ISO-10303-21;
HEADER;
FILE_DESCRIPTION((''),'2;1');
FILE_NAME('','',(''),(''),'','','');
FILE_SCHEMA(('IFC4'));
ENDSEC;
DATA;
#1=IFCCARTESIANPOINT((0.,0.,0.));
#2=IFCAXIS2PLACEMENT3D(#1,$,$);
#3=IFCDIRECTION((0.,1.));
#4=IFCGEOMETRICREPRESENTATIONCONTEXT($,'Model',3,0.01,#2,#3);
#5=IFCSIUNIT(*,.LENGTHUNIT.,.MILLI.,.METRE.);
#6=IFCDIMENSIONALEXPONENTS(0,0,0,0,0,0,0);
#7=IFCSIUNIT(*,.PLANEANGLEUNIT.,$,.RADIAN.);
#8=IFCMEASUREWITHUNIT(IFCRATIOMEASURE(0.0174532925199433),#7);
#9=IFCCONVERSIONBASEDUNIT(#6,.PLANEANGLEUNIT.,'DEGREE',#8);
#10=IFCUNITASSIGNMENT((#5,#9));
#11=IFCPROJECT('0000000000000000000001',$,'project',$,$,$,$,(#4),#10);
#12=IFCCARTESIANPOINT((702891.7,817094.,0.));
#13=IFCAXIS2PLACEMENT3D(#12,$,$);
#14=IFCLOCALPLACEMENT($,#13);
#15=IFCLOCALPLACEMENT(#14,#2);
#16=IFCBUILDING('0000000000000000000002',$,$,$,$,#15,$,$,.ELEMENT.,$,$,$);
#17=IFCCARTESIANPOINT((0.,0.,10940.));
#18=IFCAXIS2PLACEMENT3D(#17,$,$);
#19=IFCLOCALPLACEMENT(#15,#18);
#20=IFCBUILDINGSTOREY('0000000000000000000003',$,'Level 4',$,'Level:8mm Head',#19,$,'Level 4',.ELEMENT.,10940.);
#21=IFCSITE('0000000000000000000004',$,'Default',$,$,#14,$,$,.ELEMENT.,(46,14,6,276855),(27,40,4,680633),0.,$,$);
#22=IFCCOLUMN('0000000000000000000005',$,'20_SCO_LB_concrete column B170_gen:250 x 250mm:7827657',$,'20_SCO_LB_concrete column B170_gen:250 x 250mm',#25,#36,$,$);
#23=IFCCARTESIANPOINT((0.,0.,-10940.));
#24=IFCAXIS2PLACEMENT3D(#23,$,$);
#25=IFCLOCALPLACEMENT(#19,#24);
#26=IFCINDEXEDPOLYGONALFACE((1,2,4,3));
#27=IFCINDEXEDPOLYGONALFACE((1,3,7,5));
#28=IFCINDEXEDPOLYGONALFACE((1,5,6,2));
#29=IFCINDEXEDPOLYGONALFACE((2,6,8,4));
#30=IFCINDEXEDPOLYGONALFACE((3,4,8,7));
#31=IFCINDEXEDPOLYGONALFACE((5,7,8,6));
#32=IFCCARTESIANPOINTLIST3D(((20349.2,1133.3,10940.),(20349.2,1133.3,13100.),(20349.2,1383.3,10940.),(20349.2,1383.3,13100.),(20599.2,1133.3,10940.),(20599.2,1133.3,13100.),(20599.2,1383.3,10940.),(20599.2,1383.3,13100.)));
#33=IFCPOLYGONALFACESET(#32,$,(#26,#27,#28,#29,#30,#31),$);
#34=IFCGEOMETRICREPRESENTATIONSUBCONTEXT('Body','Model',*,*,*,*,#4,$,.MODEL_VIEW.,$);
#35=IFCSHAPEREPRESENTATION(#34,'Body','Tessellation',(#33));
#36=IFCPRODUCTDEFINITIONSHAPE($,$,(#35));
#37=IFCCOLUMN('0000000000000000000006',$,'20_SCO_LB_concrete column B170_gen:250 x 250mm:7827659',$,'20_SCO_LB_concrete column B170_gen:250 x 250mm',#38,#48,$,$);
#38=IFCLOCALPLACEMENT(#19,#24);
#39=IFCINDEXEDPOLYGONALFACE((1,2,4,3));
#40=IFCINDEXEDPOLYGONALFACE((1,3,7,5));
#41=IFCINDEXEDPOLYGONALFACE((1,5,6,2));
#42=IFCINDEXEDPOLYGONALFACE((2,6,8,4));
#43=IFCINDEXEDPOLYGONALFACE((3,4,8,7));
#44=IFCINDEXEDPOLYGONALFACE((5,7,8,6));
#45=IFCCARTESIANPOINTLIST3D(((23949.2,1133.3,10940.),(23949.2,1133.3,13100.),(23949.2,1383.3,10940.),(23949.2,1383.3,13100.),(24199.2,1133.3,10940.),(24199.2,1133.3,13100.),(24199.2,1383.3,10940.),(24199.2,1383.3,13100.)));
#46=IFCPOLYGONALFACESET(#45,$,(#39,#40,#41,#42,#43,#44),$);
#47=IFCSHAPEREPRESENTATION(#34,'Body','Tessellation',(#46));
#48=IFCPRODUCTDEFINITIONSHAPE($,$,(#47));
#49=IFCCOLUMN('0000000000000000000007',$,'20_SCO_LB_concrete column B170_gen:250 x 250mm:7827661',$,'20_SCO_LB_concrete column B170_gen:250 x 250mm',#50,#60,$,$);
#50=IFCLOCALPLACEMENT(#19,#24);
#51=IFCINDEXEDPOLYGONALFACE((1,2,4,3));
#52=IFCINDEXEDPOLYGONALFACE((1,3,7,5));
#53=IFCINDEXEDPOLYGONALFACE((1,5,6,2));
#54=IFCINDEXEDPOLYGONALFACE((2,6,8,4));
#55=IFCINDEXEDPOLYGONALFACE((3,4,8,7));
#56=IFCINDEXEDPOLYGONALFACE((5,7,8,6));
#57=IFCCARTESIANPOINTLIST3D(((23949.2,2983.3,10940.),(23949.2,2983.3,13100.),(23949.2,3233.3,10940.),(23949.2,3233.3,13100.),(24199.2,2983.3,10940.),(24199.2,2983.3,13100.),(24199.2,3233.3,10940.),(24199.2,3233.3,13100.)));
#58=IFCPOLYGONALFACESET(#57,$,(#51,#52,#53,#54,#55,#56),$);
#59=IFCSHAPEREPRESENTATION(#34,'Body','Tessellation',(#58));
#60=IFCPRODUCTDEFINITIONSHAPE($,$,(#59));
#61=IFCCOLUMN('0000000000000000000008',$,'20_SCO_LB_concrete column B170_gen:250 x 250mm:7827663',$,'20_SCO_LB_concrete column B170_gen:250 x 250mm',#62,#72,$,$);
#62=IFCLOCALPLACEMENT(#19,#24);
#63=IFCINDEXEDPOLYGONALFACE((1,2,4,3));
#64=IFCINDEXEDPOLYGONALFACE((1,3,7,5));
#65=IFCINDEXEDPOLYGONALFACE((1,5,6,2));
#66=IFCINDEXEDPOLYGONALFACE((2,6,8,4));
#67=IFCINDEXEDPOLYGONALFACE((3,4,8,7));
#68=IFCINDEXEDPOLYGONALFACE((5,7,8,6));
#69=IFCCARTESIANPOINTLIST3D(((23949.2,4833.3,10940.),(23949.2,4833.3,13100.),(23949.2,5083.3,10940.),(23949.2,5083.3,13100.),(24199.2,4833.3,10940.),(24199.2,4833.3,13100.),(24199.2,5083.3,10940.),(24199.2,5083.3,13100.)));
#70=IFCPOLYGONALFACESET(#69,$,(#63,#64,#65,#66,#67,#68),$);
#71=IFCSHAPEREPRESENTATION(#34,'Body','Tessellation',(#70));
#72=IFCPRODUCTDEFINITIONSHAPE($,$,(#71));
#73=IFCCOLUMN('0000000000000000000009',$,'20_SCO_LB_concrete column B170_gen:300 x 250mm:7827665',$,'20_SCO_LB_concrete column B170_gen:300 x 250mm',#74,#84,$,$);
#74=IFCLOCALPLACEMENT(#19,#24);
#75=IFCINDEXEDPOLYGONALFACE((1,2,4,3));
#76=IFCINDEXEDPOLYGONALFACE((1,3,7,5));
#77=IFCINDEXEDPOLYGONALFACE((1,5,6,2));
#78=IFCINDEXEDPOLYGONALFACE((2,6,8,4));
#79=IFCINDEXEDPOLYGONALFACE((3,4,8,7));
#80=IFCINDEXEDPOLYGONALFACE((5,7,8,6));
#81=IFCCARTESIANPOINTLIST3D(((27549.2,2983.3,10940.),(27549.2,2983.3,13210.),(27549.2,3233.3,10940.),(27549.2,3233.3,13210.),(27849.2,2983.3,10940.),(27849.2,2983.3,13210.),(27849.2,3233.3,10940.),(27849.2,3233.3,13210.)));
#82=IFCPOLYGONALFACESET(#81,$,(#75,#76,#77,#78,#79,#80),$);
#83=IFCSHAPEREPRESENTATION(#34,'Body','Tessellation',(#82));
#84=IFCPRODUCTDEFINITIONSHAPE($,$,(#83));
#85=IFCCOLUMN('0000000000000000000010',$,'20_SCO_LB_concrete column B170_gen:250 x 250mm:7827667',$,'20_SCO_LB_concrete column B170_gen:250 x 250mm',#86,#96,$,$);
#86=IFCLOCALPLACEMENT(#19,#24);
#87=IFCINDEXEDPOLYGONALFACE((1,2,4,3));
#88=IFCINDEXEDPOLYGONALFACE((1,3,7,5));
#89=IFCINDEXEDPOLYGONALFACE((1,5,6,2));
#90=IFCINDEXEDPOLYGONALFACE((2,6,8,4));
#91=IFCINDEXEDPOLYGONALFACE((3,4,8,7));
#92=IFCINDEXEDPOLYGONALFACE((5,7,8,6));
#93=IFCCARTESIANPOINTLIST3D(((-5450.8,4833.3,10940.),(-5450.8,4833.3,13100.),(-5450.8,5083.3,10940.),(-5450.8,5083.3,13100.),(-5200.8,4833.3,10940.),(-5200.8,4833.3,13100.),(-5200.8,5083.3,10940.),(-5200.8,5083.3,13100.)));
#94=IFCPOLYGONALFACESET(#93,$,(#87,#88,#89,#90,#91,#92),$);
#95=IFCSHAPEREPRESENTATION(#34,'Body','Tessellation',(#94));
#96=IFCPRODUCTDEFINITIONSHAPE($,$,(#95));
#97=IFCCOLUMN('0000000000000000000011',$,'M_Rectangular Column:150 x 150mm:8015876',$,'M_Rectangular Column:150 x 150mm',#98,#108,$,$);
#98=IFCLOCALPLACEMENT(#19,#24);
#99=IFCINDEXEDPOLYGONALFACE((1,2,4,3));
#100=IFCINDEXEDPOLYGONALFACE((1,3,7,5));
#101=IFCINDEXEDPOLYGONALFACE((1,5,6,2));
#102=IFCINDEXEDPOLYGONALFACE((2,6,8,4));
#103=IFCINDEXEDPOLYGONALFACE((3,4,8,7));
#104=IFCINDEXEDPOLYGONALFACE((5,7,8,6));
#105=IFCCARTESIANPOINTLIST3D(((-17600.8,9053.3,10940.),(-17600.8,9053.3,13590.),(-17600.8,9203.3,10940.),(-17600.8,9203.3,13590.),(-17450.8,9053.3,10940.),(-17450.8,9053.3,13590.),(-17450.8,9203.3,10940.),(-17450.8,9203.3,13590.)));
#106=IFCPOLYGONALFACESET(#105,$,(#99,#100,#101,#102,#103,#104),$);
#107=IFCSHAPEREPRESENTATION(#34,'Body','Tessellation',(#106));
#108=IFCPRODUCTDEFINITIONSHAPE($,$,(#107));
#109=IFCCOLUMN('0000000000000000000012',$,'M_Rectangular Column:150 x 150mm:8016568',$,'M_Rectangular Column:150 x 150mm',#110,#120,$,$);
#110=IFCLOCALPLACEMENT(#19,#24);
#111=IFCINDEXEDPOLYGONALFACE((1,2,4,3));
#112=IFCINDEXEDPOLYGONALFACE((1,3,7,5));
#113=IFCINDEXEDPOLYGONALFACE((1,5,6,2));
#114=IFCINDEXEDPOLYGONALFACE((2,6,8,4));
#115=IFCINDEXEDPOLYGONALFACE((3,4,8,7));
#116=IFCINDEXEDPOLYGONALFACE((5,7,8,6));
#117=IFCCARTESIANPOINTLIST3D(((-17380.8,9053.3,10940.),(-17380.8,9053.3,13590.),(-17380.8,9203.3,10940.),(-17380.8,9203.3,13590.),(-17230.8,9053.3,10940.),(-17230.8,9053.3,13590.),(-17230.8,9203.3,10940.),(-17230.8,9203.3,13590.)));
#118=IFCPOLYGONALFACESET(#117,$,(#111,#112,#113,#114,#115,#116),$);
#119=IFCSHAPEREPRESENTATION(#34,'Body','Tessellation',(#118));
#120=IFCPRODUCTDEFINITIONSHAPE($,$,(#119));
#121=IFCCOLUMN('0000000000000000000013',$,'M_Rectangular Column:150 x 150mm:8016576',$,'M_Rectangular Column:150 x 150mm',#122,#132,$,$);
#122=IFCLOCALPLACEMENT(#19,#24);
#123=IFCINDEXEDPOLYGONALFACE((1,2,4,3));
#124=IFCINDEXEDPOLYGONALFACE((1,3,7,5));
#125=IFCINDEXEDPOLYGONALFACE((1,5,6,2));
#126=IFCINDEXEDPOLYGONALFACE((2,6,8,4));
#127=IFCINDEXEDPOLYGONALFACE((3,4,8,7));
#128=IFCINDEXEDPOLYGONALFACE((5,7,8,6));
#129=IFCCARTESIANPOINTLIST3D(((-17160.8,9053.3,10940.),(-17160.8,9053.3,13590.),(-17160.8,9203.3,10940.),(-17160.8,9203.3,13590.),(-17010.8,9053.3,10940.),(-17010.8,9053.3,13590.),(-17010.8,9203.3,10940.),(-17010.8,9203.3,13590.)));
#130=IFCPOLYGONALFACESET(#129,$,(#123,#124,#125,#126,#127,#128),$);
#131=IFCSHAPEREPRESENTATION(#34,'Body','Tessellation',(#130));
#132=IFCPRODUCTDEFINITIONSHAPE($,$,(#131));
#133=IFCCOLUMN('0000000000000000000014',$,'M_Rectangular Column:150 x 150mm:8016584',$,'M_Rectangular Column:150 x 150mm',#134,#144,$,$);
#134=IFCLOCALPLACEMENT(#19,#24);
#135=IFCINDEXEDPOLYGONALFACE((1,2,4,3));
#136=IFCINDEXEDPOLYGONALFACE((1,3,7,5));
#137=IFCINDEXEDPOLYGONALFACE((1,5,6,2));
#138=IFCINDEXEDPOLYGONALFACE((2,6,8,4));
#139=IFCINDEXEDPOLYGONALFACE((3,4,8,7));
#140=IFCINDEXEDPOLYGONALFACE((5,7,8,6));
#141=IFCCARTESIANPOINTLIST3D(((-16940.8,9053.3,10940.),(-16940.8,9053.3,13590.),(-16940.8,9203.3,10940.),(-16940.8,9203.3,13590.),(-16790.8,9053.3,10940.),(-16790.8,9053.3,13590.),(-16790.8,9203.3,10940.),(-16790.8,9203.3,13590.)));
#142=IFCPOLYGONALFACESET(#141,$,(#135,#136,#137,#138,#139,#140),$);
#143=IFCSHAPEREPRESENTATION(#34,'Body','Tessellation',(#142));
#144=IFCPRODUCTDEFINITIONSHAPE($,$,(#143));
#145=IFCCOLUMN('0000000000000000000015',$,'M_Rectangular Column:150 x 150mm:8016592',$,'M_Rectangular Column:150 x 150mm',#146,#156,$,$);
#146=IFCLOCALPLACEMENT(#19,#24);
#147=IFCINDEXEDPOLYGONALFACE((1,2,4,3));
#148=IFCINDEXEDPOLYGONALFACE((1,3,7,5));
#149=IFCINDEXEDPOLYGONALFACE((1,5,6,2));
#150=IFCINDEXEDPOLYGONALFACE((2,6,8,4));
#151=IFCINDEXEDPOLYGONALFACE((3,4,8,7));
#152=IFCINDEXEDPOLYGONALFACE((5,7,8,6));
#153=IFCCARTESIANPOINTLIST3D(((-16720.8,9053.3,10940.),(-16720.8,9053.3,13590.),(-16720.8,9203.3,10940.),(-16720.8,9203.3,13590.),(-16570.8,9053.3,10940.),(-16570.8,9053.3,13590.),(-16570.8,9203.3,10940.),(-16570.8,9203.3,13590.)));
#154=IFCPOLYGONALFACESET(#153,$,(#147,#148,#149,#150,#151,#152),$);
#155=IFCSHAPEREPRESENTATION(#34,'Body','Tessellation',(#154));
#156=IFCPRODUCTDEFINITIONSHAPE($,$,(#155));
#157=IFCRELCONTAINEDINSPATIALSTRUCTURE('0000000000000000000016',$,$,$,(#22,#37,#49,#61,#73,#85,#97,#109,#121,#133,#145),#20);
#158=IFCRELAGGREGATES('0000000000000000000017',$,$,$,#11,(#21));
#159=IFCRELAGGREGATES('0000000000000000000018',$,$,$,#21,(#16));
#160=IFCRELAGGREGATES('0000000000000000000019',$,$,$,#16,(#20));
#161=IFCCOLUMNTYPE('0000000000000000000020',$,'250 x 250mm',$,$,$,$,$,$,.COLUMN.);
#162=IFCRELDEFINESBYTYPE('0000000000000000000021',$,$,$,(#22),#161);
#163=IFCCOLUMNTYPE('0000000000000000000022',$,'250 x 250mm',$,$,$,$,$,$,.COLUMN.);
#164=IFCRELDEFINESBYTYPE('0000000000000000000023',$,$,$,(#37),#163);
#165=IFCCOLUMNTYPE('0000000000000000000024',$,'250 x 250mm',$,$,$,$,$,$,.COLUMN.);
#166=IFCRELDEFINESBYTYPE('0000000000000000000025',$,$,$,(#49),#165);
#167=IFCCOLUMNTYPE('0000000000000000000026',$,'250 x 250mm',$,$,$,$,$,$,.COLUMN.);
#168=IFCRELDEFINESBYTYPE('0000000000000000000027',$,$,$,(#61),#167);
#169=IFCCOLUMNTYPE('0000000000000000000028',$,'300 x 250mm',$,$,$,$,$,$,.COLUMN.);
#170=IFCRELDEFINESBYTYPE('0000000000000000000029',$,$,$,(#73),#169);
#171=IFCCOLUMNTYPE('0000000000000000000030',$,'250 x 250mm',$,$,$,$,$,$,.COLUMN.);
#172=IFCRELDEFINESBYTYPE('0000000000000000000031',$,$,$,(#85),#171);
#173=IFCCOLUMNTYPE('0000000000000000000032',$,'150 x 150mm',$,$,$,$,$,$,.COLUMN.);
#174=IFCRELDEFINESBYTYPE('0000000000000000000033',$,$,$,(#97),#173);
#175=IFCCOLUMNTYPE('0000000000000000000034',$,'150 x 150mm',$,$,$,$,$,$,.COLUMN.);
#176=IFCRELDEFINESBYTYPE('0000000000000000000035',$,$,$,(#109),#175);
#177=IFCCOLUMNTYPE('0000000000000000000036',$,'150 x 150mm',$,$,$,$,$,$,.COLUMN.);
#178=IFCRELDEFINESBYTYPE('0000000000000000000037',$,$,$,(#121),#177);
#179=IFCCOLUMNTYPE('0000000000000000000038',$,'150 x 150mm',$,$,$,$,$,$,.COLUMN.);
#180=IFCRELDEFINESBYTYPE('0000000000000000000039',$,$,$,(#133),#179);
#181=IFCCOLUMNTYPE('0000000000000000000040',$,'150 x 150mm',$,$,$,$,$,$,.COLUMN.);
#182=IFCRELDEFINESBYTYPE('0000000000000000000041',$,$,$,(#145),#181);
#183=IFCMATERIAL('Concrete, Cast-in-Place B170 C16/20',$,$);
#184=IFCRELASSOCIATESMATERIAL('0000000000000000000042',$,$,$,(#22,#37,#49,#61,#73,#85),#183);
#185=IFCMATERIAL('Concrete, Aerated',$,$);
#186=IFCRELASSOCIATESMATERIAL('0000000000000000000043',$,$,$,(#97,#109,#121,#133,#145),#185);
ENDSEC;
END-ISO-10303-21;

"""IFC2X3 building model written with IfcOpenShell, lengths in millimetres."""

from ifc_helpers import new_model, entity, si_unit, converted_unit, direction, frame, frame_2d, origin, place, context, subcontext, project, spatial, rectangle, extrude, source, transform, mapped, material, type_object, type_shapes, element, save


model = new_model("IFC2X3")

# Units and contexts
model_context = context("Model", 3, precision=0.01, world=origin(), true_north=direction((0.0, 1.0)))
body_context = subcontext(model_context, "Body", "Model", "MODEL_VIEW")
ifc_project = project(units=[si_unit("LENGTHUNIT", "METRE", prefix="MILLI"), converted_unit("PLANEANGLEUNIT", "DEGREE", entity("IfcRatioMeasure", 0.0174532925199433), si_unit("PLANEANGLEUNIT", "RADIAN"), dimensions=[0, 0, 0, 0, 0, 0, 0])], contexts=[model_context])

# Site, building, storey
site_placement = place(None, frame((702891.7, 817094.0, 0.0)))
site = spatial("IfcSite", under=ifc_project, at=site_placement, Name="Default", CompositionType="ELEMENT", RefLatitude=(46, 14, 6, 276855), RefLongitude=(27, 40, 4, 680633), RefElevation=0.0)
building_placement = place(site_placement, origin())
building = spatial("IfcBuilding", under=site, at=building_placement, CompositionType="ELEMENT")
storey_placement = place(building_placement, frame((0.0, 0.0, 10940.0)))
storey = spatial("IfcBuildingStorey", under=building, at=storey_placement, Name="Level 4", ObjectType="Level:8mm Head", LongName="Level 4", CompositionType="ELEMENT", Elevation=10940.0)

# Columns
ifc_material_1 = material(Name="Concrete, Cast-in-Place B170 C16/20")
column_type_1 = type_object("IfcColumnType", Name="250 x 250mm", PredefinedType="COLUMN")
shared_shape_1 = source(origin(), body_context, "Body", "SweptSolid", [
    extrude(rectangle(XDim=250.0, YDim=250.0, at=frame_2d((0.0, 0.0), x_axis=(1.0, 0.0))), frame((20474.2, 1258.3, 10940.0), z_axis=(0.0, 0.0, 1.0), x_axis=(0.0, -1.0, 0.0)), (0.0, 0.0, 1.0), 2160.0),
])
type_shapes(column_type_1, [shared_shape_1])
column_1_placement = place(storey_placement, frame((0.0, 0.0, -10940.0)))
element("IfcColumn", 1, at=column_1_placement, inside=storey, type_object=column_type_1, material=ifc_material_1, Name="20_SCO_LB_concrete column B170_gen:250 x 250mm:7827657", ObjectType="20_SCO_LB_concrete column B170_gen:250 x 250mm", context=body_context, shape_type="MappedRepresentation", body=[
    mapped(shared_shape_1, transform((0.0, 0.0, 0.0), scale=1.0)),
])
column_type_2 = type_object("IfcColumnType", Name="250 x 250mm", PredefinedType="COLUMN")
shared_shape_2 = source(origin(), body_context, "Body", "SweptSolid", [
    extrude(rectangle(XDim=250.0, YDim=250.0, at=frame_2d((0.0, 0.0), x_axis=(1.0, 0.0))), frame((24074.2, 1258.3, 10940.0), z_axis=(0.0, 0.0, 1.0), x_axis=(0.0, -1.0, 0.0)), (0.0, 0.0, 1.0), 2160.0),
])
type_shapes(column_type_2, [shared_shape_2])
column_2_placement = place(storey_placement, frame((0.0, 0.0, -10940.0)))
element("IfcColumn", 2, at=column_2_placement, inside=storey, type_object=column_type_2, material=ifc_material_1, Name="20_SCO_LB_concrete column B170_gen:250 x 250mm:7827659", ObjectType="20_SCO_LB_concrete column B170_gen:250 x 250mm", context=body_context, shape_type="MappedRepresentation", body=[
    mapped(shared_shape_2, transform((0.0, 0.0, 0.0), scale=1.0)),
])
column_type_3 = type_object("IfcColumnType", Name="250 x 250mm", PredefinedType="COLUMN")
shared_shape_3 = source(origin(), body_context, "Body", "SweptSolid", [
    extrude(rectangle(XDim=250.0, YDim=250.0, at=frame_2d((0.0, 0.0), x_axis=(1.0, 0.0))), frame((24074.2, 3108.3, 10940.0), z_axis=(0.0, 0.0, 1.0), x_axis=(0.0, -1.0, 0.0)), (0.0, 0.0, 1.0), 2160.0),
])
type_shapes(column_type_3, [shared_shape_3])
column_3_placement = place(storey_placement, frame((0.0, 0.0, -10940.0)))
element("IfcColumn", 3, at=column_3_placement, inside=storey, type_object=column_type_3, material=ifc_material_1, Name="20_SCO_LB_concrete column B170_gen:250 x 250mm:7827661", ObjectType="20_SCO_LB_concrete column B170_gen:250 x 250mm", context=body_context, shape_type="MappedRepresentation", body=[
    mapped(shared_shape_3, transform((0.0, 0.0, 0.0), scale=1.0)),
])
column_type_4 = type_object("IfcColumnType", Name="250 x 250mm", PredefinedType="COLUMN")
shared_shape_4 = source(origin(), body_context, "Body", "SweptSolid", [
    extrude(rectangle(XDim=250.0, YDim=250.0, at=frame_2d((0.0, 0.0), x_axis=(1.0, 0.0))), frame((24074.2, 4958.3, 10940.0), z_axis=(0.0, 0.0, 1.0), x_axis=(0.0, -1.0, 0.0)), (0.0, 0.0, 1.0), 2160.0),
])
type_shapes(column_type_4, [shared_shape_4])
column_4_placement = place(storey_placement, frame((0.0, 0.0, -10940.0)))
element("IfcColumn", 4, at=column_4_placement, inside=storey, type_object=column_type_4, material=ifc_material_1, Name="20_SCO_LB_concrete column B170_gen:250 x 250mm:7827663", ObjectType="20_SCO_LB_concrete column B170_gen:250 x 250mm", context=body_context, shape_type="MappedRepresentation", body=[
    mapped(shared_shape_4, transform((0.0, 0.0, 0.0), scale=1.0)),
])
column_type_5 = type_object("IfcColumnType", Name="300 x 250mm", PredefinedType="COLUMN")
shared_shape_5 = source(origin(), body_context, "Body", "SweptSolid", [
    extrude(rectangle(XDim=250.0, YDim=300.0, at=frame_2d((0.0, 0.0), x_axis=(1.0, 0.0))), frame((27699.2, 3108.3, 10940.0), z_axis=(0.0, 0.0, 1.0), x_axis=(0.0, -1.0, 0.0)), (0.0, 0.0, 1.0), 2270.0),
])
type_shapes(column_type_5, [shared_shape_5])
column_5_placement = place(storey_placement, frame((0.0, 0.0, -10940.0)))
element("IfcColumn", 5, at=column_5_placement, inside=storey, type_object=column_type_5, material=ifc_material_1, Name="20_SCO_LB_concrete column B170_gen:300 x 250mm:7827665", ObjectType="20_SCO_LB_concrete column B170_gen:300 x 250mm", context=body_context, shape_type="MappedRepresentation", body=[
    mapped(shared_shape_5, transform((0.0, 0.0, 0.0), scale=1.0)),
])
column_type_6 = type_object("IfcColumnType", Name="250 x 250mm", PredefinedType="COLUMN")
shared_shape_6 = source(origin(), body_context, "Body", "SweptSolid", [
    extrude(rectangle(XDim=250.0, YDim=250.0, at=frame_2d((0.0, 0.0), x_axis=(1.0, 0.0))), frame((-5325.8, 4958.3, 10940.0), z_axis=(0.0, 0.0, 1.0), x_axis=(0.0, -1.0, 0.0)), (0.0, 0.0, 1.0), 2160.0),
])
type_shapes(column_type_6, [shared_shape_6])
column_6_placement = place(storey_placement, frame((0.0, 0.0, -10940.0)))
element("IfcColumn", 6, at=column_6_placement, inside=storey, type_object=column_type_6, material=ifc_material_1, Name="20_SCO_LB_concrete column B170_gen:250 x 250mm:7827667", ObjectType="20_SCO_LB_concrete column B170_gen:250 x 250mm", context=body_context, shape_type="MappedRepresentation", body=[
    mapped(shared_shape_6, transform((0.0, 0.0, 0.0), scale=1.0)),
])
ifc_material_2 = material(Name="Concrete, Aerated")
column_type_7 = type_object("IfcColumnType", Name="150 x 150mm", PredefinedType="COLUMN")
shared_shape_7 = source(origin(), body_context, "Body", "SweptSolid", [
    extrude(rectangle(XDim=150.0, YDim=150.0, at=frame_2d((0.0, 0.0), x_axis=(1.0, 0.0))), frame((-17525.8, 9128.3, 10940.0), z_axis=(0.0, 0.0, 1.0), x_axis=(0.0, -1.0, 0.0)), (0.0, 0.0, 1.0), 2650.0),
])
type_shapes(column_type_7, [shared_shape_7])
column_7_placement = place(storey_placement, frame((0.0, 0.0, -10940.0)))
element("IfcColumn", 7, at=column_7_placement, inside=storey, type_object=column_type_7, material=ifc_material_2, Name="M_Rectangular Column:150 x 150mm:8015876", ObjectType="M_Rectangular Column:150 x 150mm", context=body_context, shape_type="MappedRepresentation", body=[
    mapped(shared_shape_7, transform((0.0, 0.0, 0.0), scale=1.0)),
])
column_type_8 = type_object("IfcColumnType", Name="150 x 150mm", PredefinedType="COLUMN")
shared_shape_8 = source(origin(), body_context, "Body", "SweptSolid", [
    extrude(rectangle(XDim=150.0, YDim=150.0, at=frame_2d((0.0, 0.0), x_axis=(1.0, 0.0))), frame((-17305.8, 9128.3, 10940.0), z_axis=(0.0, 0.0, 1.0), x_axis=(0.0, -1.0, 0.0)), (0.0, 0.0, 1.0), 2650.0),
])
type_shapes(column_type_8, [shared_shape_8])
column_8_placement = place(storey_placement, frame((0.0, 0.0, -10940.0)))
element("IfcColumn", 8, at=column_8_placement, inside=storey, type_object=column_type_8, material=ifc_material_2, Name="M_Rectangular Column:150 x 150mm:8016568", ObjectType="M_Rectangular Column:150 x 150mm", context=body_context, shape_type="MappedRepresentation", body=[
    mapped(shared_shape_8, transform((0.0, 0.0, 0.0), scale=1.0)),
])
column_type_9 = type_object("IfcColumnType", Name="150 x 150mm", PredefinedType="COLUMN")
shared_shape_9 = source(origin(), body_context, "Body", "SweptSolid", [
    extrude(rectangle(XDim=150.0, YDim=150.0, at=frame_2d((0.0, 0.0), x_axis=(1.0, 0.0))), frame((-17085.8, 9128.3, 10940.0), z_axis=(0.0, 0.0, 1.0), x_axis=(0.0, -1.0, 0.0)), (0.0, 0.0, 1.0), 2650.0),
])
type_shapes(column_type_9, [shared_shape_9])
column_9_placement = place(storey_placement, frame((0.0, 0.0, -10940.0)))
element("IfcColumn", 9, at=column_9_placement, inside=storey, type_object=column_type_9, material=ifc_material_2, Name="M_Rectangular Column:150 x 150mm:8016576", ObjectType="M_Rectangular Column:150 x 150mm", context=body_context, shape_type="MappedRepresentation", body=[
    mapped(shared_shape_9, transform((0.0, 0.0, 0.0), scale=1.0)),
])
column_type_10 = type_object("IfcColumnType", Name="150 x 150mm", PredefinedType="COLUMN")
shared_shape_10 = source(origin(), body_context, "Body", "SweptSolid", [
    extrude(rectangle(XDim=150.0, YDim=150.0, at=frame_2d((0.0, 0.0), x_axis=(1.0, 0.0))), frame((-16865.8, 9128.3, 10940.0), z_axis=(0.0, 0.0, 1.0), x_axis=(0.0, -1.0, 0.0)), (0.0, 0.0, 1.0), 2650.0),
])
type_shapes(column_type_10, [shared_shape_10])
column_10_placement = place(storey_placement, frame((0.0, 0.0, -10940.0)))
element("IfcColumn", 10, at=column_10_placement, inside=storey, type_object=column_type_10, material=ifc_material_2, Name="M_Rectangular Column:150 x 150mm:8016584", ObjectType="M_Rectangular Column:150 x 150mm", context=body_context, shape_type="MappedRepresentation", body=[
    mapped(shared_shape_10, transform((0.0, 0.0, 0.0), scale=1.0)),
])
column_type_11 = type_object("IfcColumnType", Name="150 x 150mm", PredefinedType="COLUMN")
shared_shape_11 = source(origin(), body_context, "Body", "SweptSolid", [
    extrude(rectangle(XDim=150.0, YDim=150.0, at=frame_2d((0.0, 0.0), x_axis=(1.0, 0.0))), frame((-16645.8, 9128.3, 10940.0), z_axis=(0.0, 0.0, 1.0), x_axis=(0.0, -1.0, 0.0)), (0.0, 0.0, 1.0), 2650.0),
])
type_shapes(column_type_11, [shared_shape_11])
column_11_placement = place(storey_placement, frame((0.0, 0.0, -10940.0)))
element("IfcColumn", 11, at=column_11_placement, inside=storey, type_object=column_type_11, material=ifc_material_2, Name="M_Rectangular Column:150 x 150mm:8016592", ObjectType="M_Rectangular Column:150 x 150mm", context=body_context, shape_type="MappedRepresentation", body=[
    mapped(shared_shape_11, transform((0.0, 0.0, 0.0), scale=1.0)),
])

save(model, "model.ifc")
